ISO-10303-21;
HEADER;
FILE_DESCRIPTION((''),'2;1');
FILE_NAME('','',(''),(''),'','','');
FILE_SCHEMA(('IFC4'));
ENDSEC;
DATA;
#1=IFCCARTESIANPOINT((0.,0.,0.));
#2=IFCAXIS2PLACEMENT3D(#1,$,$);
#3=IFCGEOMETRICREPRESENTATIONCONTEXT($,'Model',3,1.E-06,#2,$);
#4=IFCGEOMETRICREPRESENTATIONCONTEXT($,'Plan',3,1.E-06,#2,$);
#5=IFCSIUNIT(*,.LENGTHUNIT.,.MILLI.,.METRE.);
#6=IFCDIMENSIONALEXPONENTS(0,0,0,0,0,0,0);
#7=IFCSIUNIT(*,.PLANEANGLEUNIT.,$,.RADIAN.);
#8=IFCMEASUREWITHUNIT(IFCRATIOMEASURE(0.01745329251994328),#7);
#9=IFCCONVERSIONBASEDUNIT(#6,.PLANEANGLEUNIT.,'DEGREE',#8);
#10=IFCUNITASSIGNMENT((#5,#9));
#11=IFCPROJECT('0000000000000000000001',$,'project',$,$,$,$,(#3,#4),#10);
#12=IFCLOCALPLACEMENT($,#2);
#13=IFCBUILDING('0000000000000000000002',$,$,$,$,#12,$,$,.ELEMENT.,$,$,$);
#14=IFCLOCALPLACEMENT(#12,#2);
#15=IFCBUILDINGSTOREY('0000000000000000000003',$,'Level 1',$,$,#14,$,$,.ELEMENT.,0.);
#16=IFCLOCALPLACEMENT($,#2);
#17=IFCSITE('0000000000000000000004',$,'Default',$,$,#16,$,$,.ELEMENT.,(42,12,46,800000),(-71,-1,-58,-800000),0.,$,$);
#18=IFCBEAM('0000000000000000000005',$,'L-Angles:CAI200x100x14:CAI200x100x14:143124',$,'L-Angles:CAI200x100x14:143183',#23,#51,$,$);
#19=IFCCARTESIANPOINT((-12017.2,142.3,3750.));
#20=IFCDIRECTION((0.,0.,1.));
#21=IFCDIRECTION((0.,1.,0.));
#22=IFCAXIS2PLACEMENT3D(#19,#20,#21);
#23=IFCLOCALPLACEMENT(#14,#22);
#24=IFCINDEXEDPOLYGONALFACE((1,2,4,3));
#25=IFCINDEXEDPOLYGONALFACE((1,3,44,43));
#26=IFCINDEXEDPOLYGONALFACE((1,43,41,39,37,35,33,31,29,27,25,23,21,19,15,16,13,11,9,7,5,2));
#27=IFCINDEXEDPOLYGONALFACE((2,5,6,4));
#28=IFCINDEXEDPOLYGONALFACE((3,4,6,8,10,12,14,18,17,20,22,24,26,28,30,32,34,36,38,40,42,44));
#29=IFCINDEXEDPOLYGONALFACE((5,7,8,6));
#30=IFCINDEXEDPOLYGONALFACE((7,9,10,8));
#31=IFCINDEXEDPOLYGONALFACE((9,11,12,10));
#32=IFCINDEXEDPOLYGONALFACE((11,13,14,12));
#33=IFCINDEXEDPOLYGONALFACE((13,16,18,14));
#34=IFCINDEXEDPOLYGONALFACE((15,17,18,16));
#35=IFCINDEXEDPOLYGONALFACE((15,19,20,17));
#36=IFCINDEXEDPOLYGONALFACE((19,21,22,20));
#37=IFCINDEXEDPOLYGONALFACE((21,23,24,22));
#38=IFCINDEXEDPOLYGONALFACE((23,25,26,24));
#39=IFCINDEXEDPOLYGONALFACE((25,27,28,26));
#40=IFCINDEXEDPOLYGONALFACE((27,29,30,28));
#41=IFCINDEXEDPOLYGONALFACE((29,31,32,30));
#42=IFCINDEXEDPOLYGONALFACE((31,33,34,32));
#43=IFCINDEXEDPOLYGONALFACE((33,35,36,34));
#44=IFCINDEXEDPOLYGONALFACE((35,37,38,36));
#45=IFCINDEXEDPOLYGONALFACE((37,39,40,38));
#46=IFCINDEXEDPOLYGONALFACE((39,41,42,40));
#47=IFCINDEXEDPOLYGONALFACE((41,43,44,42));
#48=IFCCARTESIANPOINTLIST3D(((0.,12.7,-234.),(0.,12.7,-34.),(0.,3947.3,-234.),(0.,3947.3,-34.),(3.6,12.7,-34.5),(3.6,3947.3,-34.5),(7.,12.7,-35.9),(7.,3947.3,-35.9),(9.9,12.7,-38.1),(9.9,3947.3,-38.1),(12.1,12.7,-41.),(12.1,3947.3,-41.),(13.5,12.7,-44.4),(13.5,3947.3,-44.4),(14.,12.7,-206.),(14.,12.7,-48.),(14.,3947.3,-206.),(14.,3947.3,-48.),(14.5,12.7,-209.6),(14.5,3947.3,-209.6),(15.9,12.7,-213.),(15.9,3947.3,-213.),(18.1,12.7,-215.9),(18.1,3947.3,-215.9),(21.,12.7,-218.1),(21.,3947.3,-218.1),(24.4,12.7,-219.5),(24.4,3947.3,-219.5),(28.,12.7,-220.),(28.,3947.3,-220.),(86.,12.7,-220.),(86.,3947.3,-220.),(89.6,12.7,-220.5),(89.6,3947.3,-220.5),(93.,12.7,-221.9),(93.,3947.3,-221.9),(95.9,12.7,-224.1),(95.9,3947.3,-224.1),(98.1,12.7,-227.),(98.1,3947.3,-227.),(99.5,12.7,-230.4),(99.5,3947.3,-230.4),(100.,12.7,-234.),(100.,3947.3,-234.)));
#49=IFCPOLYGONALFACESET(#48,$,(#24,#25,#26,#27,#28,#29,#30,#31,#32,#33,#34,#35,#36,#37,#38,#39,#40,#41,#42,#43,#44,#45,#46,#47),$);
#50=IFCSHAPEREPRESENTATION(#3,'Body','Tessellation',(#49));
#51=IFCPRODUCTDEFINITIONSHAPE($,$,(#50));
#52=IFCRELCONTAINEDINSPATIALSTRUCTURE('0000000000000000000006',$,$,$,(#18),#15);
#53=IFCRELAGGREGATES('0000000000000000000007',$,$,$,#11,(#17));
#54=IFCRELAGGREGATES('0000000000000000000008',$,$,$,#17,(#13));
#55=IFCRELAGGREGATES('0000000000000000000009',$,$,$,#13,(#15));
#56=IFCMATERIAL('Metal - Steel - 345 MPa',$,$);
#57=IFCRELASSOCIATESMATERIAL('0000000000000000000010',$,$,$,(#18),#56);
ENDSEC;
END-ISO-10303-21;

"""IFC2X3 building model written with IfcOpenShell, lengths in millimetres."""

from ifc_helpers import new_model, entity, si_unit, converted_unit, frame, frame_2d, origin, place, context, project, spatial, polyline, circle_curve, parameter, trimmed, segment, composite_curve, outline, extrude, material, element, save


model = new_model("IFC2X3")

# Units and contexts
model_context = context("Model", 3, precision=1e-06, world=origin())
plan_context = context("Plan", 3, precision=1e-06, world=origin())
ifc_project = project(units=[si_unit("LENGTHUNIT", "METRE", prefix="MILLI"), converted_unit("PLANEANGLEUNIT", "DEGREE", entity("IfcRatioMeasure", 0.01745329251994328), si_unit("PLANEANGLEUNIT", "RADIAN"), dimensions=[0, 0, 0, 0, 0, 0, 0])], contexts=[model_context, plan_context])

# Site, building, storey
site_placement = place(None, origin())
site = spatial("IfcSite", under=ifc_project, at=site_placement, Name="Default", CompositionType="ELEMENT", RefLatitude=(42, 12, 46, 800000), RefLongitude=(-71, -1, -58, -800000), RefElevation=0.0)
building_placement = place(None, origin())
building = spatial("IfcBuilding", under=site, at=building_placement, CompositionType="ELEMENT")
storey_placement = place(building_placement, origin())
storey = spatial("IfcBuildingStorey", under=building, at=storey_placement, Name="Level 1", CompositionType="ELEMENT", Elevation=0.0)

# Shared definitions
ifc_material_1 = material(Name="Metal - Steel - 345 MPa")

# Beam
beam_1_placement = place(storey_placement, frame((-12017.2, 142.3, 3750.0), z_axis=(0.0, 0.0, 1.0), x_axis=(0.0, 1.0, 0.0)))
element("IfcBeam", 1, at=beam_1_placement, inside=storey, material=ifc_material_1, Name="L-Angles:CAI200x100x14:CAI200x100x14:143124", ObjectType="L-Angles:CAI200x100x14:143183", context=model_context, shape_type="SweptSolid", body=[
    extrude(outline(composite_curve([segment(polyline([(-34.6, -63.1), (65.4, -63.1)]), True, "CONTINUOUS"), segment(trimmed(circle_curve(frame_2d((51.4, -63.1), x_axis=(1.0, 0.0)), 14.0), [parameter(0.0)], [parameter(90.0)], True, "PARAMETER"), True, "CONTINUOUS"), segment(polyline([(51.4, -49.1), (-6.6, -49.1)]), True, "CONTINUOUS"), segment(trimmed(circle_curve(frame_2d((-6.6, -35.1), x_axis=(1.0, 0.0)), 14.0), [parameter(180.0)], [parameter(270.0)], True, "PARAMETER"), False, "CONTINUOUS"), segment(polyline([(-20.6, -35.1), (-20.6, 122.9)]), True, "CONTINUOUS"), segment(trimmed(circle_curve(frame_2d((-34.6, 122.9), x_axis=(1.0, 0.0)), 14.0), [parameter(0.0)], [parameter(90.0)], True, "PARAMETER"), True, "CONTINUOUS"), segment(polyline([(-34.6, 136.9), (-34.6, -63.1)]), True, "CONTINUOUS")], self_intersect=False)), frame((34.6, 3947.3, -170.9), z_axis=(0.0, -1.0, 0.0), x_axis=(1.0, 0.0, 0.0)), (0.0, 0.0, 1.0), 3934.6),
])

save(model, "model.ifc")
